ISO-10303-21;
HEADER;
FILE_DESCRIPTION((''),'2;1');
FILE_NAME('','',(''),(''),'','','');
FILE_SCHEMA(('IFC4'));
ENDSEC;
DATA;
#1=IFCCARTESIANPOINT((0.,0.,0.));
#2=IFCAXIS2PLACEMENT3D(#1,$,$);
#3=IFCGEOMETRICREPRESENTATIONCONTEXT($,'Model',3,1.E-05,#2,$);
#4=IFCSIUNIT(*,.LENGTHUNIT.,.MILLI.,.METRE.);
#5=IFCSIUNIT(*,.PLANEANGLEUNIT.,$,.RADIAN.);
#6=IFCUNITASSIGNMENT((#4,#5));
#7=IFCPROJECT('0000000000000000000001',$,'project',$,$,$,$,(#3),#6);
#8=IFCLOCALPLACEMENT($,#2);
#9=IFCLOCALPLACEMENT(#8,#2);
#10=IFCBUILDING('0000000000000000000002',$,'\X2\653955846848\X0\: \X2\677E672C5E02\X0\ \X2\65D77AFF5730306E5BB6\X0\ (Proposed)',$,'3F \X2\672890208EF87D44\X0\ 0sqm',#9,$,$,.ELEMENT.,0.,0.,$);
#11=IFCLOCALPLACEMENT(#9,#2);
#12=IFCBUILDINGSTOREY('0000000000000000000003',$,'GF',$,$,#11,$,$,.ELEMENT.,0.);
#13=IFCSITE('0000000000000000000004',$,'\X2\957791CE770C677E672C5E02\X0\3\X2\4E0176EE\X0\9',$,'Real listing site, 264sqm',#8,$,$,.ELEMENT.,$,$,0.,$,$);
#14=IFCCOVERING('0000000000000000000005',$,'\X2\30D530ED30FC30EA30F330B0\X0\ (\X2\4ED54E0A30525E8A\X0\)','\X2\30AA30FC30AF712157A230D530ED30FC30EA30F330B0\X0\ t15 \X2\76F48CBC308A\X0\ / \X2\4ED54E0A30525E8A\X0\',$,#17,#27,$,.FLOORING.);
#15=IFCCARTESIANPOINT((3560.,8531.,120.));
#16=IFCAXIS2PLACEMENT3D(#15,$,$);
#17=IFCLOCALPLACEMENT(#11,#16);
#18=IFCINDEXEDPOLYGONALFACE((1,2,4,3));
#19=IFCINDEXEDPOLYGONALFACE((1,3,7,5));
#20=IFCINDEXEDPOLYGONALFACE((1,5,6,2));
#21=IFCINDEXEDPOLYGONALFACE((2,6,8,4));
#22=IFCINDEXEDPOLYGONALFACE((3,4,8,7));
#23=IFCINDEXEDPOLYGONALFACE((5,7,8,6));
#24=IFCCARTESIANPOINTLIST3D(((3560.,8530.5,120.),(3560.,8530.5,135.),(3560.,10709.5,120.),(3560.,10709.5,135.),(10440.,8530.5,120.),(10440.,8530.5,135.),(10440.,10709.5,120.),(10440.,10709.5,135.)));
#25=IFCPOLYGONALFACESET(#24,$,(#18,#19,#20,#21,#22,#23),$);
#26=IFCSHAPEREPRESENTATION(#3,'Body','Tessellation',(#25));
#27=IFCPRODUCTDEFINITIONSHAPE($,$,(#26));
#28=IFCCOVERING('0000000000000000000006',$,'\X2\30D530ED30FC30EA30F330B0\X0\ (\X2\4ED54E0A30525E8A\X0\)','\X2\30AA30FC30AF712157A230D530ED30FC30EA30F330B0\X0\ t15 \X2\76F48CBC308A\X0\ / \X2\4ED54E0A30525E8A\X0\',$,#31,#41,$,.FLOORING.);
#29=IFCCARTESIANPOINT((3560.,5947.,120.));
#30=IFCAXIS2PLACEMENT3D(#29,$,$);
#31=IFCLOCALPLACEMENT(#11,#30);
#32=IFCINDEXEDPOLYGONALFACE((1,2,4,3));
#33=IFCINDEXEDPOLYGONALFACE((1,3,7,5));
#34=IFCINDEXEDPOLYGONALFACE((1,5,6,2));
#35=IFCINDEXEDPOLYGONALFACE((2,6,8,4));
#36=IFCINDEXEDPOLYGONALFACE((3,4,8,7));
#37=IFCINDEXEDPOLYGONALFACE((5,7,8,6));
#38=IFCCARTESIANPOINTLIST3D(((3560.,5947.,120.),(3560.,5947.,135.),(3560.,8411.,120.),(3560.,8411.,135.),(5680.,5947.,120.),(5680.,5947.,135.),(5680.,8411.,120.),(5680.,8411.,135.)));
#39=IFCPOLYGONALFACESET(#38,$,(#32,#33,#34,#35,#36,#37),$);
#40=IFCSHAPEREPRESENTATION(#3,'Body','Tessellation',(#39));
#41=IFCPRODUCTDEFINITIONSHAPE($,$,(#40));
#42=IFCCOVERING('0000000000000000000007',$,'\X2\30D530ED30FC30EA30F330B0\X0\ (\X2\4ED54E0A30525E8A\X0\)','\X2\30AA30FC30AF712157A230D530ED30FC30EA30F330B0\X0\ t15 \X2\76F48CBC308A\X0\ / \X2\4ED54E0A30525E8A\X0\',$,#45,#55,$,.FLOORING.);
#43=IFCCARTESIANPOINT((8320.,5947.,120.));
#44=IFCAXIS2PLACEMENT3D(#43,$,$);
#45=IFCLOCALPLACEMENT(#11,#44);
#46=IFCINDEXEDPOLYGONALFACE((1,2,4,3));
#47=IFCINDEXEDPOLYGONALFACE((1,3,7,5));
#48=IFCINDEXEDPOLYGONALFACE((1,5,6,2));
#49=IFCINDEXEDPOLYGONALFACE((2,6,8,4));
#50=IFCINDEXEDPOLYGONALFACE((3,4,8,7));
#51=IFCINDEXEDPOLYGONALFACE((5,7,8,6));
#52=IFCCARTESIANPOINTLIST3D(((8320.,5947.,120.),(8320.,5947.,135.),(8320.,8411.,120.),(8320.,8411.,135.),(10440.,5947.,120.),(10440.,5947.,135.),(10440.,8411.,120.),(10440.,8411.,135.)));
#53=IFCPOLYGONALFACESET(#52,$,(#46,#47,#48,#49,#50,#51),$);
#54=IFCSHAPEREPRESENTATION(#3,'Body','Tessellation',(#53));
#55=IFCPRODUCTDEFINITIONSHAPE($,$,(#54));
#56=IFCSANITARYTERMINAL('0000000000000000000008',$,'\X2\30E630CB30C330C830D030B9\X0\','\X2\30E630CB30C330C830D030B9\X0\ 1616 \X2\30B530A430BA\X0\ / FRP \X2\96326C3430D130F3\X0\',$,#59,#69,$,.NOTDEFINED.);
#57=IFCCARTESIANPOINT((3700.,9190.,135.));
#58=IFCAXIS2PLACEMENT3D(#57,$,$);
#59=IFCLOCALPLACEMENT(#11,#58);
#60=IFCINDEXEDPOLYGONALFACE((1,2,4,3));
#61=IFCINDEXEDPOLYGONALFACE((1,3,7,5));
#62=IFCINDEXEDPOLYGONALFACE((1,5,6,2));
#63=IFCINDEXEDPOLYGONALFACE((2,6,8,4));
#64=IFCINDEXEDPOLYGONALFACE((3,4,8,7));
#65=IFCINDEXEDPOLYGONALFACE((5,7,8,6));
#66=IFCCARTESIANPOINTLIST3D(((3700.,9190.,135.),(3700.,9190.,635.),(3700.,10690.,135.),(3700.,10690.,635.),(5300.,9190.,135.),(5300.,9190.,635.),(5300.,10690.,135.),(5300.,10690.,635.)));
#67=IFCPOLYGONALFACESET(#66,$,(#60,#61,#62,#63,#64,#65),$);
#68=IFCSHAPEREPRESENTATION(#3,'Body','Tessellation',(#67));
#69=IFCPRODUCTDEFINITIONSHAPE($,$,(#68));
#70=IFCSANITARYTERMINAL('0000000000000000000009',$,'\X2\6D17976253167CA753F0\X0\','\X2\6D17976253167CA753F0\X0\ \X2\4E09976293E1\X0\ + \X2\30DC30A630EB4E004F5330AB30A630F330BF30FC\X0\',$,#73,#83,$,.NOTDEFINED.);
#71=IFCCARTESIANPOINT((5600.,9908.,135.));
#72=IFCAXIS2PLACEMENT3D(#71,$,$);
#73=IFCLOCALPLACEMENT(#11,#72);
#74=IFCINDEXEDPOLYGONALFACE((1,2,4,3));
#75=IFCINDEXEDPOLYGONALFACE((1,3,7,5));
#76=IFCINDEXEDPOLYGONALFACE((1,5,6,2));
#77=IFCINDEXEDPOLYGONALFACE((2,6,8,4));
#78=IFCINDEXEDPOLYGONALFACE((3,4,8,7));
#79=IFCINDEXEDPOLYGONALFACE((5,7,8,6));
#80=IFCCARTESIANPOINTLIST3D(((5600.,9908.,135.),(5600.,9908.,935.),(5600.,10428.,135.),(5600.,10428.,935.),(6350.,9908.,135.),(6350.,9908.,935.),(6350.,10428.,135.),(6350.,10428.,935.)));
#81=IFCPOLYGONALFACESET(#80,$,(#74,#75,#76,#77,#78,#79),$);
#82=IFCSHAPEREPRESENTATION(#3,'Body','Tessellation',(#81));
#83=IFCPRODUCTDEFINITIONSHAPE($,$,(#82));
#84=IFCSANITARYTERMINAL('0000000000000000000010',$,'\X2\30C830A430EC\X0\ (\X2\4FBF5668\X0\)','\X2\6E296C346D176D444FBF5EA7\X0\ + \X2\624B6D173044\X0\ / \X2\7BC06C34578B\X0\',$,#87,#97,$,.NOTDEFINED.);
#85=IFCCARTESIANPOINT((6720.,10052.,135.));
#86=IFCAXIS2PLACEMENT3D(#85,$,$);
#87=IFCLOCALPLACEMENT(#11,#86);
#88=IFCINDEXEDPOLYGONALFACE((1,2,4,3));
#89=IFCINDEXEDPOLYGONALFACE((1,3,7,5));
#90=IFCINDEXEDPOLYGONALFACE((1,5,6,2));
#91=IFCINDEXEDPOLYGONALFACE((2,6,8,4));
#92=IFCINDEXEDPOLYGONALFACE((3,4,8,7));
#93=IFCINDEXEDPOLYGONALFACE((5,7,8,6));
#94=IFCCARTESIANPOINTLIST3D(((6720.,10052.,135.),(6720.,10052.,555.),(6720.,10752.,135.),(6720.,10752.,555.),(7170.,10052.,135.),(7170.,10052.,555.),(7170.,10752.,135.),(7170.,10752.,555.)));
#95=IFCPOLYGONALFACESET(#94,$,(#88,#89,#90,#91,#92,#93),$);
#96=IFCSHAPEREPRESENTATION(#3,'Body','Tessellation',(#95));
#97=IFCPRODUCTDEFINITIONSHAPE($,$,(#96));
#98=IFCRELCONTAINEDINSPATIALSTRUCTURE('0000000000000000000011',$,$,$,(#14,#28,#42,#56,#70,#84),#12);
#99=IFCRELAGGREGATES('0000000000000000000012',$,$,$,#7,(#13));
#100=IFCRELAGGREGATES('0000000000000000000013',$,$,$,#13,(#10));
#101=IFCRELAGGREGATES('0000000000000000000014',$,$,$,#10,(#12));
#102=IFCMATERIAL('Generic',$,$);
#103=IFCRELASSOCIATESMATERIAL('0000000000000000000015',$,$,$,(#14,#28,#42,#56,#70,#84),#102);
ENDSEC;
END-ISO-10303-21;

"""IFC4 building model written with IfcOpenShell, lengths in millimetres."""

from ifc_helpers import new_model, si_unit, frame, frame_2d, origin, place, context, project, spatial, rectangle, extrude, material, element, save


model = new_model("IFC4")

# Units and contexts
model_context = context("Model", 3, precision=1e-05, world=origin())
ifc_project = project(units=[si_unit("LENGTHUNIT", "METRE", prefix="MILLI"), si_unit("PLANEANGLEUNIT", "RADIAN")], contexts=[model_context])

# Site, building, storey
site_placement = place(None, origin())
site = spatial("IfcSite", under=ifc_project, at=site_placement, Name="長野県松本市3丁目9", ObjectType="Real listing site, 264sqm", CompositionType="ELEMENT", RefElevation=0.0)
building_placement = place(site_placement, origin())
building = spatial("IfcBuilding", under=site, at=building_placement, Name="改善案: 松本市 旗竿地の家 (Proposed)", ObjectType="3F 木造軸組 0sqm", CompositionType="ELEMENT", ElevationOfRefHeight=0.0, ElevationOfTerrain=0.0)
storey_placement = place(building_placement, origin())
storey = spatial("IfcBuildingStorey", under=building, at=storey_placement, Name="GF", CompositionType="ELEMENT", Elevation=0.0)

# Coverings
ifc_material_1 = material(Name="Generic")
covering_1_placement = place(storey_placement, frame((3560.0, 8531.0, 120.0)))
element("IfcCovering", 1, at=covering_1_placement, inside=storey, material=ifc_material_1, Name="フローリング (仕上げ床)", Description="オーク無垢フローリング t15 直貼り / 仕上げ床", PredefinedType="FLOORING", context=model_context, shape_type="SweptSolid", body=[
    extrude(rectangle(XDim=6880.0, YDim=2179.0, at=frame_2d((3440.0, 1089.0))), frame((3560.0, 8531.0, 120.0)), (0.0, 0.0, 1.0), 15.0),
])
covering_2_placement = place(storey_placement, frame((3560.0, 5947.0, 120.0)))
element("IfcCovering", 2, at=covering_2_placement, inside=storey, material=ifc_material_1, Name="フローリング (仕上げ床)", Description="オーク無垢フローリング t15 直貼り / 仕上げ床", PredefinedType="FLOORING", context=model_context, shape_type="SweptSolid", body=[
    extrude(rectangle(XDim=2120.0, YDim=2464.0, at=frame_2d((1060.0, 1232.0))), frame((3560.0, 5947.0, 120.0)), (0.0, 0.0, 1.0), 15.0),
])
covering_3_placement = place(storey_placement, frame((8320.0, 5947.0, 120.0)))
element("IfcCovering", 3, at=covering_3_placement, inside=storey, material=ifc_material_1, Name="フローリング (仕上げ床)", Description="オーク無垢フローリング t15 直貼り / 仕上げ床", PredefinedType="FLOORING", context=model_context, shape_type="SweptSolid", body=[
    extrude(rectangle(XDim=2120.0, YDim=2464.0, at=frame_2d((1060.0, 1232.0))), frame((8320.0, 5947.0, 120.0)), (0.0, 0.0, 1.0), 15.0),
])

# Sanitary terminals
sanitary_terminal_1_placement = place(storey_placement, frame((3700.0, 9190.0, 135.0)))
element("IfcSanitaryTerminal", 4, at=sanitary_terminal_1_placement, inside=storey, material=ifc_material_1, Name="ユニットバス", Description="ユニットバス 1616 サイズ / FRP 防水パン", PredefinedType="NOTDEFINED", context=model_context, shape_type="SweptSolid", body=[
    extrude(rectangle(XDim=1600.0, YDim=1500.0, at=frame_2d((800.0, 750.0))), frame((3700.0, 9190.0, 135.0)), (0.0, 0.0, 1.0), 500.0),
])
sanitary_terminal_2_placement = place(storey_placement, frame((5600.0, 9908.0, 135.0)))
element("IfcSanitaryTerminal", 5, at=sanitary_terminal_2_placement, inside=storey, material=ifc_material_1, Name="洗面化粧台", Description="洗面化粧台 三面鏡 + ボウル一体カウンター", PredefinedType="NOTDEFINED", context=model_context, shape_type="SweptSolid", body=[
    extrude(rectangle(XDim=750.0, YDim=520.0, at=frame_2d((375.0, 260.0))), frame((5600.0, 9908.0, 135.0)), (0.0, 0.0, 1.0), 800.0),
])
sanitary_terminal_3_placement = place(storey_placement, frame((6720.0, 10052.0, 135.0)))
element("IfcSanitaryTerminal", 6, at=sanitary_terminal_3_placement, inside=storey, material=ifc_material_1, Name="トイレ (便器)", Description="温水洗浄便座 + 手洗い / 節水型", PredefinedType="NOTDEFINED", context=model_context, shape_type="SweptSolid", body=[
    extrude(rectangle(XDim=450.0, YDim=700.0, at=frame_2d((225.0, 350.0))), frame((6720.0, 10052.0, 135.0)), (0.0, 0.0, 1.0), 420.0),
])

save(model, "model.ifc")
